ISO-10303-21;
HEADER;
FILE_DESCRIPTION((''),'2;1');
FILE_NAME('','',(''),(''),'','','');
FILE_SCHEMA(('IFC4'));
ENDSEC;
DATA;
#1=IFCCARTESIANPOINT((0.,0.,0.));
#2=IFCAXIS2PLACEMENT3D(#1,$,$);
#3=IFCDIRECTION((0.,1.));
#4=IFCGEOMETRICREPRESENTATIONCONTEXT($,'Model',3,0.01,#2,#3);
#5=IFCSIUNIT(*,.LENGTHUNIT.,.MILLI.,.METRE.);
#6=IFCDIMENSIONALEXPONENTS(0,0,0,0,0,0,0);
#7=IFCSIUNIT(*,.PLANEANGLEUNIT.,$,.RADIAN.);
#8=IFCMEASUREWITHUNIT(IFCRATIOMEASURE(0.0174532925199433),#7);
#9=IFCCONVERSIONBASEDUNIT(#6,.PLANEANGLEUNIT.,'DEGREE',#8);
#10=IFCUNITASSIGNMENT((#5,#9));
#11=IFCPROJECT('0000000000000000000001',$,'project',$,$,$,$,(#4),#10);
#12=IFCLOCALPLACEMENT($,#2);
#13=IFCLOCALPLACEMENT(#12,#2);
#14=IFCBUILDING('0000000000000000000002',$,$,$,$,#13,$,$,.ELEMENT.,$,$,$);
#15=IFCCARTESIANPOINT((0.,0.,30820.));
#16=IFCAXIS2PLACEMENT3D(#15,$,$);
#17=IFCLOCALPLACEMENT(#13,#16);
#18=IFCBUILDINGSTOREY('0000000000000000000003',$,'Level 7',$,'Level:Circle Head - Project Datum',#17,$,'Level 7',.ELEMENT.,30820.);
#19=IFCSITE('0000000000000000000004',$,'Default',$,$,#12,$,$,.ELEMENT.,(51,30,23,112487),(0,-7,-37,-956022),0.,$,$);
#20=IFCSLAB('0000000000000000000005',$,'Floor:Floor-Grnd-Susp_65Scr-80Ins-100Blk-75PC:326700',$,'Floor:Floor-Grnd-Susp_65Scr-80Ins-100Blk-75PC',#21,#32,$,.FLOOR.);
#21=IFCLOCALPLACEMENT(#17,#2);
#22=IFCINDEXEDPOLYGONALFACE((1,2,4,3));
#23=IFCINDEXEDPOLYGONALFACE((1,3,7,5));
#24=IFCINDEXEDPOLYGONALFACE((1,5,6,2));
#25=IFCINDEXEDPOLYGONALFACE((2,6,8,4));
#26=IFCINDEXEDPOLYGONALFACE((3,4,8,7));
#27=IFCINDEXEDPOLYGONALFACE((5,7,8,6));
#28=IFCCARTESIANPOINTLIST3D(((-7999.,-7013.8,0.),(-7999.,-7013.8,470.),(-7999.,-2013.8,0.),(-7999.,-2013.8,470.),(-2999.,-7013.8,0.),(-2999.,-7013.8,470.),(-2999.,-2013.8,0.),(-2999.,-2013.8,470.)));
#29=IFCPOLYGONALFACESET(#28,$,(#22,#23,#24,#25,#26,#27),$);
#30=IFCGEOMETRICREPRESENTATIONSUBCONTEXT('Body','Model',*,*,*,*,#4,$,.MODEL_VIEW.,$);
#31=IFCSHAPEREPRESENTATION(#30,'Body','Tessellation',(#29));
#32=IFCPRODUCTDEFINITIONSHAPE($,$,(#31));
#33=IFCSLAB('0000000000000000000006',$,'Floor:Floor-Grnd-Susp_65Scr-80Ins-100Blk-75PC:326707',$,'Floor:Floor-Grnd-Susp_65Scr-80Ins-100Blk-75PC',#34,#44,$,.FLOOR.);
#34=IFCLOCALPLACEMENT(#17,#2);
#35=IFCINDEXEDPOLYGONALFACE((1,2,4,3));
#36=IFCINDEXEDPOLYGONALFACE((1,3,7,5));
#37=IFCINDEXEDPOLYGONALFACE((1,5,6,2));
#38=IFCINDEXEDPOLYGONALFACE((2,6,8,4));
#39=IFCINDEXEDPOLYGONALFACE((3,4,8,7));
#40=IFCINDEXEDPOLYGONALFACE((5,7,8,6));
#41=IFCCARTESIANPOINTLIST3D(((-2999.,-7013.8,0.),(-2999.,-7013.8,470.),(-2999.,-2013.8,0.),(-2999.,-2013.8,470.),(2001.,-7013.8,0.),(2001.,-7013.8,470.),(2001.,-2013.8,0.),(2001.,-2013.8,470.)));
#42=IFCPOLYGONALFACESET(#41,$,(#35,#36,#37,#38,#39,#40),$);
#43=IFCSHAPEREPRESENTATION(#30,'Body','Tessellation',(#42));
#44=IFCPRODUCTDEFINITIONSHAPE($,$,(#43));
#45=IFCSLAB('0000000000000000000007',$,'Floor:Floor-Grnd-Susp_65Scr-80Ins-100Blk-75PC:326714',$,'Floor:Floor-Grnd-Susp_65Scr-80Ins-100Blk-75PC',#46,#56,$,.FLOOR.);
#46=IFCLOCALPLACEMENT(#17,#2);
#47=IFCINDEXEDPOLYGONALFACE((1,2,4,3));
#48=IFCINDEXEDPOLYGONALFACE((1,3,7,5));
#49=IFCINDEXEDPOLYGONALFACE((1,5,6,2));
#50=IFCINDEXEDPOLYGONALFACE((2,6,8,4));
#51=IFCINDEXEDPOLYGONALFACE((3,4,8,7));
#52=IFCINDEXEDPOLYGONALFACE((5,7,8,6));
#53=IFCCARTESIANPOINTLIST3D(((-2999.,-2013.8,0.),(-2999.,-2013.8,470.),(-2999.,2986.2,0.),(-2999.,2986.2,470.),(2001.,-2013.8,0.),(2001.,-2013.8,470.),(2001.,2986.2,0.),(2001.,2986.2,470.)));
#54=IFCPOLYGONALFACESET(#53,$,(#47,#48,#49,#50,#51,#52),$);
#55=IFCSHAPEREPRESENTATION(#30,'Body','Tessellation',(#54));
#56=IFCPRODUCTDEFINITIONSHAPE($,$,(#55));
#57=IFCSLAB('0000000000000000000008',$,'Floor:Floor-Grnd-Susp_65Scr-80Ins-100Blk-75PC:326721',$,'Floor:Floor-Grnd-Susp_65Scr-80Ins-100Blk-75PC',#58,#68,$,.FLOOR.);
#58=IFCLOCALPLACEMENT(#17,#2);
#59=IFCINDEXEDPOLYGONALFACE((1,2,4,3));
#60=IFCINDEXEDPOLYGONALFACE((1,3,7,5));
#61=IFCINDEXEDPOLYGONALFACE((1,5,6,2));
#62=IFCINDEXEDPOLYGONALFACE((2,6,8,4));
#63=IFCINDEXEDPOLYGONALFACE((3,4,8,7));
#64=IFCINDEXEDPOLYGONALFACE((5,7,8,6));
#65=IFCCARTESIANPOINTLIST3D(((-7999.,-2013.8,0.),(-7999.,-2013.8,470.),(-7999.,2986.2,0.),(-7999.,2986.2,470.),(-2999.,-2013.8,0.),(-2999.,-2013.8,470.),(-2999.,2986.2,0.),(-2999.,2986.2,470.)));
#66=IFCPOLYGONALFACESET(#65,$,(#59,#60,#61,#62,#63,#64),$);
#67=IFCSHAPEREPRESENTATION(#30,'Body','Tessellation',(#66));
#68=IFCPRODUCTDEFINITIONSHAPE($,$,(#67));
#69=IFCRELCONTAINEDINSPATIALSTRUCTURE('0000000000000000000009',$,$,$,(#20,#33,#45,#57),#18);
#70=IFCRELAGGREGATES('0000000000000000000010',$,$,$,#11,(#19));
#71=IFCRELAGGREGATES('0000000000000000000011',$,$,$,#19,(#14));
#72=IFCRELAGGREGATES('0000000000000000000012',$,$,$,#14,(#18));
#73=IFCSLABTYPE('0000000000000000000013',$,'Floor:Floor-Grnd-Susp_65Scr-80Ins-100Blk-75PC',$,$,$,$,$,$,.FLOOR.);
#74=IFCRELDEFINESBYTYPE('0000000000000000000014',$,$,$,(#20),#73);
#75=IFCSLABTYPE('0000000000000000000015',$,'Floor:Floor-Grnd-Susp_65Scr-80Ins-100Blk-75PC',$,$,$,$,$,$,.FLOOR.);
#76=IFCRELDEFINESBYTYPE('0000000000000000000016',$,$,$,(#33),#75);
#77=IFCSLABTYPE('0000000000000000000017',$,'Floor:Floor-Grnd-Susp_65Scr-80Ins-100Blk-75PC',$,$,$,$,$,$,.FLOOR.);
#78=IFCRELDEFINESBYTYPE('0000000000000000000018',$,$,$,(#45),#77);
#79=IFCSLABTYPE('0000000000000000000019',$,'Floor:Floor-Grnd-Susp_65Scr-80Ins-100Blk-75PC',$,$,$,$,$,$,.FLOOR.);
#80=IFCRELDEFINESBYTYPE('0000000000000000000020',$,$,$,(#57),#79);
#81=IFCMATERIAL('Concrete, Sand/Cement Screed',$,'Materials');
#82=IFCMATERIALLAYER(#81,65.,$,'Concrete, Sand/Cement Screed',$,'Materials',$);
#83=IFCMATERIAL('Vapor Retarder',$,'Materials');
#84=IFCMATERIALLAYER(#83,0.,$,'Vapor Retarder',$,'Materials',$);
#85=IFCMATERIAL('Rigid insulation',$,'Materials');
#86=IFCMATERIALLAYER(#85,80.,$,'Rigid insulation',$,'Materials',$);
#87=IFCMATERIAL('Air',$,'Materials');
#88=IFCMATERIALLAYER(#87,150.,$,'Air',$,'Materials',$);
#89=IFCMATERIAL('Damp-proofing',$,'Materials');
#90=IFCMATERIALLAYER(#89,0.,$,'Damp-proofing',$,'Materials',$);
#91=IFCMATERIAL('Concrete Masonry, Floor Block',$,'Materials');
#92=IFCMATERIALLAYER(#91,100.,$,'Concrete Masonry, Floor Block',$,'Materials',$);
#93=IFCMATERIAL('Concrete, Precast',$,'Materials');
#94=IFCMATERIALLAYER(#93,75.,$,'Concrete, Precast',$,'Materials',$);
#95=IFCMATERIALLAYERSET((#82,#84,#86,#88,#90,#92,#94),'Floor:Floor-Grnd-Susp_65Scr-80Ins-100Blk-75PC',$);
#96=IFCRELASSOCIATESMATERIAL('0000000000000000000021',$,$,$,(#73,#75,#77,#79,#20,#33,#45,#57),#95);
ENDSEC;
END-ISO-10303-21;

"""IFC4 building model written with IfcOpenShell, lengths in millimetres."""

from ifc_helpers import new_model, entity, si_unit, converted_unit, direction, frame, frame_2d, origin, origin_2d_with_axis, place, context, subcontext, project, spatial, rectangle, extrude, material, layer, layer_set, layer_usage, type_object, element, save


model = new_model("IFC4")

# Units and contexts
model_context = context("Model", 3, precision=0.01, world=origin(), true_north=direction((0.0, 1.0)))
body_context = subcontext(model_context, "Body", "Model", "MODEL_VIEW")
ifc_project = project(units=[si_unit("LENGTHUNIT", "METRE", prefix="MILLI"), converted_unit("PLANEANGLEUNIT", "DEGREE", entity("IfcRatioMeasure", 0.0174532925199433), si_unit("PLANEANGLEUNIT", "RADIAN"), dimensions=[0, 0, 0, 0, 0, 0, 0])], contexts=[model_context])

# Site, building, storey
site_placement = place(None, origin())
site = spatial("IfcSite", under=ifc_project, at=site_placement, Name="Default", CompositionType="ELEMENT", RefLatitude=(51, 30, 23, 112487), RefLongitude=(0, -7, -37, -956022), RefElevation=0.0)
building_placement = place(site_placement, origin())
building = spatial("IfcBuilding", under=site, at=building_placement, CompositionType="ELEMENT")
storey_placement = place(building_placement, frame((0.0, 0.0, 30820.0)))
storey = spatial("IfcBuildingStorey", under=building, at=storey_placement, Name="Level 7", ObjectType="Level:Circle Head - Project Datum", LongName="Level 7", CompositionType="ELEMENT", Elevation=30820.0)

# Slabs
ifc_material_1 = material(Name="Concrete, Sand/Cement Screed", Category="Materials")
ifc_layer_1 = layer(ifc_material_1, 65.0, Name="Concrete, Sand/Cement Screed", Category="Materials")
ifc_material_2 = material(Name="Vapor Retarder", Category="Materials")
ifc_layer_2 = layer(ifc_material_2, 0.0, Name="Vapor Retarder", Category="Materials")
ifc_material_3 = material(Name="Rigid insulation", Category="Materials")
ifc_layer_3 = layer(ifc_material_3, 80.0, Name="Rigid insulation", Category="Materials")
ifc_material_4 = material(Name="Air", Category="Materials")
ifc_layer_4 = layer(ifc_material_4, 150.0, Name="Air", Category="Materials")
ifc_material_5 = material(Name="Damp-proofing", Category="Materials")
ifc_layer_5 = layer(ifc_material_5, 0.0, Name="Damp-proofing", Category="Materials")
ifc_material_6 = material(Name="Concrete Masonry, Floor Block", Category="Materials")
ifc_layer_6 = layer(ifc_material_6, 100.0, Name="Concrete Masonry, Floor Block", Category="Materials")
ifc_material_7 = material(Name="Concrete, Precast", Category="Materials")
ifc_layer_7 = layer(ifc_material_7, 75.0, Name="Concrete, Precast", Category="Materials")
ifc_layer_set = layer_set([ifc_layer_1, ifc_layer_2, ifc_layer_3, ifc_layer_4, ifc_layer_5, ifc_layer_6, ifc_layer_7], Name="Floor:Floor-Grnd-Susp_65Scr-80Ins-100Blk-75PC")
ifc_layer_usage_1 = layer_usage(ifc_layer_set, "AXIS3", "POSITIVE", 0.0)
slab_type_1 = type_object("IfcSlabType", Name="Floor:Floor-Grnd-Susp_65Scr-80Ins-100Blk-75PC", PredefinedType="FLOOR", material=ifc_layer_set)
slab_1_placement = place(storey_placement, origin())
element("IfcSlab", 1, at=slab_1_placement, inside=storey, type_object=slab_type_1, material=ifc_layer_usage_1, Name="Floor:Floor-Grnd-Susp_65Scr-80Ins-100Blk-75PC:326700", ObjectType="Floor:Floor-Grnd-Susp_65Scr-80Ins-100Blk-75PC", PredefinedType="FLOOR", context=body_context, shape_type="SweptSolid", body=[
    extrude(rectangle(XDim=5000.0, YDim=5000.0, at=frame_2d((0.0, 0.0), x_axis=(1.0, 0.0))), frame((-5499.0, -4513.8, 470.0), z_axis=(0.0, 0.0, -1.0), x_axis=(0.0, 1.0, 0.0)), (0.0, 0.0, 1.0), 470.0),
])
ifc_layer_usage_2 = layer_usage(ifc_layer_set, "AXIS3", "POSITIVE", 0.0)
slab_type_2 = type_object("IfcSlabType", Name="Floor:Floor-Grnd-Susp_65Scr-80Ins-100Blk-75PC", PredefinedType="FLOOR", material=ifc_layer_set)
slab_2_placement = place(storey_placement, origin())
element("IfcSlab", 2, at=slab_2_placement, inside=storey, type_object=slab_type_2, material=ifc_layer_usage_2, Name="Floor:Floor-Grnd-Susp_65Scr-80Ins-100Blk-75PC:326707", ObjectType="Floor:Floor-Grnd-Susp_65Scr-80Ins-100Blk-75PC", PredefinedType="FLOOR", context=body_context, shape_type="SweptSolid", body=[
    extrude(rectangle(XDim=5000.0, YDim=5000.0, at=frame_2d((0.0, 0.0), x_axis=(1.0, 0.0))), frame((-499.0, -4513.8, 470.0), z_axis=(0.0, 0.0, -1.0), x_axis=(0.0, 1.0, 0.0)), (0.0, 0.0, 1.0), 470.0),
])
ifc_layer_usage_3 = layer_usage(ifc_layer_set, "AXIS3", "POSITIVE", 0.0)
slab_type_3 = type_object("IfcSlabType", Name="Floor:Floor-Grnd-Susp_65Scr-80Ins-100Blk-75PC", PredefinedType="FLOOR", material=ifc_layer_set)
slab_3_placement = place(storey_placement, origin())
element("IfcSlab", 3, at=slab_3_placement, inside=storey, type_object=slab_type_3, material=ifc_layer_usage_3, Name="Floor:Floor-Grnd-Susp_65Scr-80Ins-100Blk-75PC:326714", ObjectType="Floor:Floor-Grnd-Susp_65Scr-80Ins-100Blk-75PC", PredefinedType="FLOOR", context=body_context, shape_type="SweptSolid", body=[
    extrude(rectangle(XDim=5000.0, YDim=5000.0, at=origin_2d_with_axis()), frame((-499.0, 486.2, 470.0), z_axis=(0.0, 0.0, -1.0), x_axis=(0.0, 1.0, 0.0)), (0.0, 0.0, 1.0), 470.0),
])
ifc_layer_usage_4 = layer_usage(ifc_layer_set, "AXIS3", "POSITIVE", 0.0)
slab_type_4 = type_object("IfcSlabType", Name="Floor:Floor-Grnd-Susp_65Scr-80Ins-100Blk-75PC", PredefinedType="FLOOR", material=ifc_layer_set)
slab_4_placement = place(storey_placement, origin())
element("IfcSlab", 4, at=slab_4_placement, inside=storey, type_object=slab_type_4, material=ifc_layer_usage_4, Name="Floor:Floor-Grnd-Susp_65Scr-80Ins-100Blk-75PC:326721", ObjectType="Floor:Floor-Grnd-Susp_65Scr-80Ins-100Blk-75PC", PredefinedType="FLOOR", context=body_context, shape_type="SweptSolid", body=[
    extrude(rectangle(XDim=5000.0, YDim=5000.0, at=frame_2d((0.0, 0.0), x_axis=(1.0, 0.0))), frame((-5499.0, 486.2, 470.0), z_axis=(0.0, 0.0, -1.0), x_axis=(0.0, 1.0, 0.0)), (0.0, 0.0, 1.0), 470.0),
])

save(model, "model.ifc")
